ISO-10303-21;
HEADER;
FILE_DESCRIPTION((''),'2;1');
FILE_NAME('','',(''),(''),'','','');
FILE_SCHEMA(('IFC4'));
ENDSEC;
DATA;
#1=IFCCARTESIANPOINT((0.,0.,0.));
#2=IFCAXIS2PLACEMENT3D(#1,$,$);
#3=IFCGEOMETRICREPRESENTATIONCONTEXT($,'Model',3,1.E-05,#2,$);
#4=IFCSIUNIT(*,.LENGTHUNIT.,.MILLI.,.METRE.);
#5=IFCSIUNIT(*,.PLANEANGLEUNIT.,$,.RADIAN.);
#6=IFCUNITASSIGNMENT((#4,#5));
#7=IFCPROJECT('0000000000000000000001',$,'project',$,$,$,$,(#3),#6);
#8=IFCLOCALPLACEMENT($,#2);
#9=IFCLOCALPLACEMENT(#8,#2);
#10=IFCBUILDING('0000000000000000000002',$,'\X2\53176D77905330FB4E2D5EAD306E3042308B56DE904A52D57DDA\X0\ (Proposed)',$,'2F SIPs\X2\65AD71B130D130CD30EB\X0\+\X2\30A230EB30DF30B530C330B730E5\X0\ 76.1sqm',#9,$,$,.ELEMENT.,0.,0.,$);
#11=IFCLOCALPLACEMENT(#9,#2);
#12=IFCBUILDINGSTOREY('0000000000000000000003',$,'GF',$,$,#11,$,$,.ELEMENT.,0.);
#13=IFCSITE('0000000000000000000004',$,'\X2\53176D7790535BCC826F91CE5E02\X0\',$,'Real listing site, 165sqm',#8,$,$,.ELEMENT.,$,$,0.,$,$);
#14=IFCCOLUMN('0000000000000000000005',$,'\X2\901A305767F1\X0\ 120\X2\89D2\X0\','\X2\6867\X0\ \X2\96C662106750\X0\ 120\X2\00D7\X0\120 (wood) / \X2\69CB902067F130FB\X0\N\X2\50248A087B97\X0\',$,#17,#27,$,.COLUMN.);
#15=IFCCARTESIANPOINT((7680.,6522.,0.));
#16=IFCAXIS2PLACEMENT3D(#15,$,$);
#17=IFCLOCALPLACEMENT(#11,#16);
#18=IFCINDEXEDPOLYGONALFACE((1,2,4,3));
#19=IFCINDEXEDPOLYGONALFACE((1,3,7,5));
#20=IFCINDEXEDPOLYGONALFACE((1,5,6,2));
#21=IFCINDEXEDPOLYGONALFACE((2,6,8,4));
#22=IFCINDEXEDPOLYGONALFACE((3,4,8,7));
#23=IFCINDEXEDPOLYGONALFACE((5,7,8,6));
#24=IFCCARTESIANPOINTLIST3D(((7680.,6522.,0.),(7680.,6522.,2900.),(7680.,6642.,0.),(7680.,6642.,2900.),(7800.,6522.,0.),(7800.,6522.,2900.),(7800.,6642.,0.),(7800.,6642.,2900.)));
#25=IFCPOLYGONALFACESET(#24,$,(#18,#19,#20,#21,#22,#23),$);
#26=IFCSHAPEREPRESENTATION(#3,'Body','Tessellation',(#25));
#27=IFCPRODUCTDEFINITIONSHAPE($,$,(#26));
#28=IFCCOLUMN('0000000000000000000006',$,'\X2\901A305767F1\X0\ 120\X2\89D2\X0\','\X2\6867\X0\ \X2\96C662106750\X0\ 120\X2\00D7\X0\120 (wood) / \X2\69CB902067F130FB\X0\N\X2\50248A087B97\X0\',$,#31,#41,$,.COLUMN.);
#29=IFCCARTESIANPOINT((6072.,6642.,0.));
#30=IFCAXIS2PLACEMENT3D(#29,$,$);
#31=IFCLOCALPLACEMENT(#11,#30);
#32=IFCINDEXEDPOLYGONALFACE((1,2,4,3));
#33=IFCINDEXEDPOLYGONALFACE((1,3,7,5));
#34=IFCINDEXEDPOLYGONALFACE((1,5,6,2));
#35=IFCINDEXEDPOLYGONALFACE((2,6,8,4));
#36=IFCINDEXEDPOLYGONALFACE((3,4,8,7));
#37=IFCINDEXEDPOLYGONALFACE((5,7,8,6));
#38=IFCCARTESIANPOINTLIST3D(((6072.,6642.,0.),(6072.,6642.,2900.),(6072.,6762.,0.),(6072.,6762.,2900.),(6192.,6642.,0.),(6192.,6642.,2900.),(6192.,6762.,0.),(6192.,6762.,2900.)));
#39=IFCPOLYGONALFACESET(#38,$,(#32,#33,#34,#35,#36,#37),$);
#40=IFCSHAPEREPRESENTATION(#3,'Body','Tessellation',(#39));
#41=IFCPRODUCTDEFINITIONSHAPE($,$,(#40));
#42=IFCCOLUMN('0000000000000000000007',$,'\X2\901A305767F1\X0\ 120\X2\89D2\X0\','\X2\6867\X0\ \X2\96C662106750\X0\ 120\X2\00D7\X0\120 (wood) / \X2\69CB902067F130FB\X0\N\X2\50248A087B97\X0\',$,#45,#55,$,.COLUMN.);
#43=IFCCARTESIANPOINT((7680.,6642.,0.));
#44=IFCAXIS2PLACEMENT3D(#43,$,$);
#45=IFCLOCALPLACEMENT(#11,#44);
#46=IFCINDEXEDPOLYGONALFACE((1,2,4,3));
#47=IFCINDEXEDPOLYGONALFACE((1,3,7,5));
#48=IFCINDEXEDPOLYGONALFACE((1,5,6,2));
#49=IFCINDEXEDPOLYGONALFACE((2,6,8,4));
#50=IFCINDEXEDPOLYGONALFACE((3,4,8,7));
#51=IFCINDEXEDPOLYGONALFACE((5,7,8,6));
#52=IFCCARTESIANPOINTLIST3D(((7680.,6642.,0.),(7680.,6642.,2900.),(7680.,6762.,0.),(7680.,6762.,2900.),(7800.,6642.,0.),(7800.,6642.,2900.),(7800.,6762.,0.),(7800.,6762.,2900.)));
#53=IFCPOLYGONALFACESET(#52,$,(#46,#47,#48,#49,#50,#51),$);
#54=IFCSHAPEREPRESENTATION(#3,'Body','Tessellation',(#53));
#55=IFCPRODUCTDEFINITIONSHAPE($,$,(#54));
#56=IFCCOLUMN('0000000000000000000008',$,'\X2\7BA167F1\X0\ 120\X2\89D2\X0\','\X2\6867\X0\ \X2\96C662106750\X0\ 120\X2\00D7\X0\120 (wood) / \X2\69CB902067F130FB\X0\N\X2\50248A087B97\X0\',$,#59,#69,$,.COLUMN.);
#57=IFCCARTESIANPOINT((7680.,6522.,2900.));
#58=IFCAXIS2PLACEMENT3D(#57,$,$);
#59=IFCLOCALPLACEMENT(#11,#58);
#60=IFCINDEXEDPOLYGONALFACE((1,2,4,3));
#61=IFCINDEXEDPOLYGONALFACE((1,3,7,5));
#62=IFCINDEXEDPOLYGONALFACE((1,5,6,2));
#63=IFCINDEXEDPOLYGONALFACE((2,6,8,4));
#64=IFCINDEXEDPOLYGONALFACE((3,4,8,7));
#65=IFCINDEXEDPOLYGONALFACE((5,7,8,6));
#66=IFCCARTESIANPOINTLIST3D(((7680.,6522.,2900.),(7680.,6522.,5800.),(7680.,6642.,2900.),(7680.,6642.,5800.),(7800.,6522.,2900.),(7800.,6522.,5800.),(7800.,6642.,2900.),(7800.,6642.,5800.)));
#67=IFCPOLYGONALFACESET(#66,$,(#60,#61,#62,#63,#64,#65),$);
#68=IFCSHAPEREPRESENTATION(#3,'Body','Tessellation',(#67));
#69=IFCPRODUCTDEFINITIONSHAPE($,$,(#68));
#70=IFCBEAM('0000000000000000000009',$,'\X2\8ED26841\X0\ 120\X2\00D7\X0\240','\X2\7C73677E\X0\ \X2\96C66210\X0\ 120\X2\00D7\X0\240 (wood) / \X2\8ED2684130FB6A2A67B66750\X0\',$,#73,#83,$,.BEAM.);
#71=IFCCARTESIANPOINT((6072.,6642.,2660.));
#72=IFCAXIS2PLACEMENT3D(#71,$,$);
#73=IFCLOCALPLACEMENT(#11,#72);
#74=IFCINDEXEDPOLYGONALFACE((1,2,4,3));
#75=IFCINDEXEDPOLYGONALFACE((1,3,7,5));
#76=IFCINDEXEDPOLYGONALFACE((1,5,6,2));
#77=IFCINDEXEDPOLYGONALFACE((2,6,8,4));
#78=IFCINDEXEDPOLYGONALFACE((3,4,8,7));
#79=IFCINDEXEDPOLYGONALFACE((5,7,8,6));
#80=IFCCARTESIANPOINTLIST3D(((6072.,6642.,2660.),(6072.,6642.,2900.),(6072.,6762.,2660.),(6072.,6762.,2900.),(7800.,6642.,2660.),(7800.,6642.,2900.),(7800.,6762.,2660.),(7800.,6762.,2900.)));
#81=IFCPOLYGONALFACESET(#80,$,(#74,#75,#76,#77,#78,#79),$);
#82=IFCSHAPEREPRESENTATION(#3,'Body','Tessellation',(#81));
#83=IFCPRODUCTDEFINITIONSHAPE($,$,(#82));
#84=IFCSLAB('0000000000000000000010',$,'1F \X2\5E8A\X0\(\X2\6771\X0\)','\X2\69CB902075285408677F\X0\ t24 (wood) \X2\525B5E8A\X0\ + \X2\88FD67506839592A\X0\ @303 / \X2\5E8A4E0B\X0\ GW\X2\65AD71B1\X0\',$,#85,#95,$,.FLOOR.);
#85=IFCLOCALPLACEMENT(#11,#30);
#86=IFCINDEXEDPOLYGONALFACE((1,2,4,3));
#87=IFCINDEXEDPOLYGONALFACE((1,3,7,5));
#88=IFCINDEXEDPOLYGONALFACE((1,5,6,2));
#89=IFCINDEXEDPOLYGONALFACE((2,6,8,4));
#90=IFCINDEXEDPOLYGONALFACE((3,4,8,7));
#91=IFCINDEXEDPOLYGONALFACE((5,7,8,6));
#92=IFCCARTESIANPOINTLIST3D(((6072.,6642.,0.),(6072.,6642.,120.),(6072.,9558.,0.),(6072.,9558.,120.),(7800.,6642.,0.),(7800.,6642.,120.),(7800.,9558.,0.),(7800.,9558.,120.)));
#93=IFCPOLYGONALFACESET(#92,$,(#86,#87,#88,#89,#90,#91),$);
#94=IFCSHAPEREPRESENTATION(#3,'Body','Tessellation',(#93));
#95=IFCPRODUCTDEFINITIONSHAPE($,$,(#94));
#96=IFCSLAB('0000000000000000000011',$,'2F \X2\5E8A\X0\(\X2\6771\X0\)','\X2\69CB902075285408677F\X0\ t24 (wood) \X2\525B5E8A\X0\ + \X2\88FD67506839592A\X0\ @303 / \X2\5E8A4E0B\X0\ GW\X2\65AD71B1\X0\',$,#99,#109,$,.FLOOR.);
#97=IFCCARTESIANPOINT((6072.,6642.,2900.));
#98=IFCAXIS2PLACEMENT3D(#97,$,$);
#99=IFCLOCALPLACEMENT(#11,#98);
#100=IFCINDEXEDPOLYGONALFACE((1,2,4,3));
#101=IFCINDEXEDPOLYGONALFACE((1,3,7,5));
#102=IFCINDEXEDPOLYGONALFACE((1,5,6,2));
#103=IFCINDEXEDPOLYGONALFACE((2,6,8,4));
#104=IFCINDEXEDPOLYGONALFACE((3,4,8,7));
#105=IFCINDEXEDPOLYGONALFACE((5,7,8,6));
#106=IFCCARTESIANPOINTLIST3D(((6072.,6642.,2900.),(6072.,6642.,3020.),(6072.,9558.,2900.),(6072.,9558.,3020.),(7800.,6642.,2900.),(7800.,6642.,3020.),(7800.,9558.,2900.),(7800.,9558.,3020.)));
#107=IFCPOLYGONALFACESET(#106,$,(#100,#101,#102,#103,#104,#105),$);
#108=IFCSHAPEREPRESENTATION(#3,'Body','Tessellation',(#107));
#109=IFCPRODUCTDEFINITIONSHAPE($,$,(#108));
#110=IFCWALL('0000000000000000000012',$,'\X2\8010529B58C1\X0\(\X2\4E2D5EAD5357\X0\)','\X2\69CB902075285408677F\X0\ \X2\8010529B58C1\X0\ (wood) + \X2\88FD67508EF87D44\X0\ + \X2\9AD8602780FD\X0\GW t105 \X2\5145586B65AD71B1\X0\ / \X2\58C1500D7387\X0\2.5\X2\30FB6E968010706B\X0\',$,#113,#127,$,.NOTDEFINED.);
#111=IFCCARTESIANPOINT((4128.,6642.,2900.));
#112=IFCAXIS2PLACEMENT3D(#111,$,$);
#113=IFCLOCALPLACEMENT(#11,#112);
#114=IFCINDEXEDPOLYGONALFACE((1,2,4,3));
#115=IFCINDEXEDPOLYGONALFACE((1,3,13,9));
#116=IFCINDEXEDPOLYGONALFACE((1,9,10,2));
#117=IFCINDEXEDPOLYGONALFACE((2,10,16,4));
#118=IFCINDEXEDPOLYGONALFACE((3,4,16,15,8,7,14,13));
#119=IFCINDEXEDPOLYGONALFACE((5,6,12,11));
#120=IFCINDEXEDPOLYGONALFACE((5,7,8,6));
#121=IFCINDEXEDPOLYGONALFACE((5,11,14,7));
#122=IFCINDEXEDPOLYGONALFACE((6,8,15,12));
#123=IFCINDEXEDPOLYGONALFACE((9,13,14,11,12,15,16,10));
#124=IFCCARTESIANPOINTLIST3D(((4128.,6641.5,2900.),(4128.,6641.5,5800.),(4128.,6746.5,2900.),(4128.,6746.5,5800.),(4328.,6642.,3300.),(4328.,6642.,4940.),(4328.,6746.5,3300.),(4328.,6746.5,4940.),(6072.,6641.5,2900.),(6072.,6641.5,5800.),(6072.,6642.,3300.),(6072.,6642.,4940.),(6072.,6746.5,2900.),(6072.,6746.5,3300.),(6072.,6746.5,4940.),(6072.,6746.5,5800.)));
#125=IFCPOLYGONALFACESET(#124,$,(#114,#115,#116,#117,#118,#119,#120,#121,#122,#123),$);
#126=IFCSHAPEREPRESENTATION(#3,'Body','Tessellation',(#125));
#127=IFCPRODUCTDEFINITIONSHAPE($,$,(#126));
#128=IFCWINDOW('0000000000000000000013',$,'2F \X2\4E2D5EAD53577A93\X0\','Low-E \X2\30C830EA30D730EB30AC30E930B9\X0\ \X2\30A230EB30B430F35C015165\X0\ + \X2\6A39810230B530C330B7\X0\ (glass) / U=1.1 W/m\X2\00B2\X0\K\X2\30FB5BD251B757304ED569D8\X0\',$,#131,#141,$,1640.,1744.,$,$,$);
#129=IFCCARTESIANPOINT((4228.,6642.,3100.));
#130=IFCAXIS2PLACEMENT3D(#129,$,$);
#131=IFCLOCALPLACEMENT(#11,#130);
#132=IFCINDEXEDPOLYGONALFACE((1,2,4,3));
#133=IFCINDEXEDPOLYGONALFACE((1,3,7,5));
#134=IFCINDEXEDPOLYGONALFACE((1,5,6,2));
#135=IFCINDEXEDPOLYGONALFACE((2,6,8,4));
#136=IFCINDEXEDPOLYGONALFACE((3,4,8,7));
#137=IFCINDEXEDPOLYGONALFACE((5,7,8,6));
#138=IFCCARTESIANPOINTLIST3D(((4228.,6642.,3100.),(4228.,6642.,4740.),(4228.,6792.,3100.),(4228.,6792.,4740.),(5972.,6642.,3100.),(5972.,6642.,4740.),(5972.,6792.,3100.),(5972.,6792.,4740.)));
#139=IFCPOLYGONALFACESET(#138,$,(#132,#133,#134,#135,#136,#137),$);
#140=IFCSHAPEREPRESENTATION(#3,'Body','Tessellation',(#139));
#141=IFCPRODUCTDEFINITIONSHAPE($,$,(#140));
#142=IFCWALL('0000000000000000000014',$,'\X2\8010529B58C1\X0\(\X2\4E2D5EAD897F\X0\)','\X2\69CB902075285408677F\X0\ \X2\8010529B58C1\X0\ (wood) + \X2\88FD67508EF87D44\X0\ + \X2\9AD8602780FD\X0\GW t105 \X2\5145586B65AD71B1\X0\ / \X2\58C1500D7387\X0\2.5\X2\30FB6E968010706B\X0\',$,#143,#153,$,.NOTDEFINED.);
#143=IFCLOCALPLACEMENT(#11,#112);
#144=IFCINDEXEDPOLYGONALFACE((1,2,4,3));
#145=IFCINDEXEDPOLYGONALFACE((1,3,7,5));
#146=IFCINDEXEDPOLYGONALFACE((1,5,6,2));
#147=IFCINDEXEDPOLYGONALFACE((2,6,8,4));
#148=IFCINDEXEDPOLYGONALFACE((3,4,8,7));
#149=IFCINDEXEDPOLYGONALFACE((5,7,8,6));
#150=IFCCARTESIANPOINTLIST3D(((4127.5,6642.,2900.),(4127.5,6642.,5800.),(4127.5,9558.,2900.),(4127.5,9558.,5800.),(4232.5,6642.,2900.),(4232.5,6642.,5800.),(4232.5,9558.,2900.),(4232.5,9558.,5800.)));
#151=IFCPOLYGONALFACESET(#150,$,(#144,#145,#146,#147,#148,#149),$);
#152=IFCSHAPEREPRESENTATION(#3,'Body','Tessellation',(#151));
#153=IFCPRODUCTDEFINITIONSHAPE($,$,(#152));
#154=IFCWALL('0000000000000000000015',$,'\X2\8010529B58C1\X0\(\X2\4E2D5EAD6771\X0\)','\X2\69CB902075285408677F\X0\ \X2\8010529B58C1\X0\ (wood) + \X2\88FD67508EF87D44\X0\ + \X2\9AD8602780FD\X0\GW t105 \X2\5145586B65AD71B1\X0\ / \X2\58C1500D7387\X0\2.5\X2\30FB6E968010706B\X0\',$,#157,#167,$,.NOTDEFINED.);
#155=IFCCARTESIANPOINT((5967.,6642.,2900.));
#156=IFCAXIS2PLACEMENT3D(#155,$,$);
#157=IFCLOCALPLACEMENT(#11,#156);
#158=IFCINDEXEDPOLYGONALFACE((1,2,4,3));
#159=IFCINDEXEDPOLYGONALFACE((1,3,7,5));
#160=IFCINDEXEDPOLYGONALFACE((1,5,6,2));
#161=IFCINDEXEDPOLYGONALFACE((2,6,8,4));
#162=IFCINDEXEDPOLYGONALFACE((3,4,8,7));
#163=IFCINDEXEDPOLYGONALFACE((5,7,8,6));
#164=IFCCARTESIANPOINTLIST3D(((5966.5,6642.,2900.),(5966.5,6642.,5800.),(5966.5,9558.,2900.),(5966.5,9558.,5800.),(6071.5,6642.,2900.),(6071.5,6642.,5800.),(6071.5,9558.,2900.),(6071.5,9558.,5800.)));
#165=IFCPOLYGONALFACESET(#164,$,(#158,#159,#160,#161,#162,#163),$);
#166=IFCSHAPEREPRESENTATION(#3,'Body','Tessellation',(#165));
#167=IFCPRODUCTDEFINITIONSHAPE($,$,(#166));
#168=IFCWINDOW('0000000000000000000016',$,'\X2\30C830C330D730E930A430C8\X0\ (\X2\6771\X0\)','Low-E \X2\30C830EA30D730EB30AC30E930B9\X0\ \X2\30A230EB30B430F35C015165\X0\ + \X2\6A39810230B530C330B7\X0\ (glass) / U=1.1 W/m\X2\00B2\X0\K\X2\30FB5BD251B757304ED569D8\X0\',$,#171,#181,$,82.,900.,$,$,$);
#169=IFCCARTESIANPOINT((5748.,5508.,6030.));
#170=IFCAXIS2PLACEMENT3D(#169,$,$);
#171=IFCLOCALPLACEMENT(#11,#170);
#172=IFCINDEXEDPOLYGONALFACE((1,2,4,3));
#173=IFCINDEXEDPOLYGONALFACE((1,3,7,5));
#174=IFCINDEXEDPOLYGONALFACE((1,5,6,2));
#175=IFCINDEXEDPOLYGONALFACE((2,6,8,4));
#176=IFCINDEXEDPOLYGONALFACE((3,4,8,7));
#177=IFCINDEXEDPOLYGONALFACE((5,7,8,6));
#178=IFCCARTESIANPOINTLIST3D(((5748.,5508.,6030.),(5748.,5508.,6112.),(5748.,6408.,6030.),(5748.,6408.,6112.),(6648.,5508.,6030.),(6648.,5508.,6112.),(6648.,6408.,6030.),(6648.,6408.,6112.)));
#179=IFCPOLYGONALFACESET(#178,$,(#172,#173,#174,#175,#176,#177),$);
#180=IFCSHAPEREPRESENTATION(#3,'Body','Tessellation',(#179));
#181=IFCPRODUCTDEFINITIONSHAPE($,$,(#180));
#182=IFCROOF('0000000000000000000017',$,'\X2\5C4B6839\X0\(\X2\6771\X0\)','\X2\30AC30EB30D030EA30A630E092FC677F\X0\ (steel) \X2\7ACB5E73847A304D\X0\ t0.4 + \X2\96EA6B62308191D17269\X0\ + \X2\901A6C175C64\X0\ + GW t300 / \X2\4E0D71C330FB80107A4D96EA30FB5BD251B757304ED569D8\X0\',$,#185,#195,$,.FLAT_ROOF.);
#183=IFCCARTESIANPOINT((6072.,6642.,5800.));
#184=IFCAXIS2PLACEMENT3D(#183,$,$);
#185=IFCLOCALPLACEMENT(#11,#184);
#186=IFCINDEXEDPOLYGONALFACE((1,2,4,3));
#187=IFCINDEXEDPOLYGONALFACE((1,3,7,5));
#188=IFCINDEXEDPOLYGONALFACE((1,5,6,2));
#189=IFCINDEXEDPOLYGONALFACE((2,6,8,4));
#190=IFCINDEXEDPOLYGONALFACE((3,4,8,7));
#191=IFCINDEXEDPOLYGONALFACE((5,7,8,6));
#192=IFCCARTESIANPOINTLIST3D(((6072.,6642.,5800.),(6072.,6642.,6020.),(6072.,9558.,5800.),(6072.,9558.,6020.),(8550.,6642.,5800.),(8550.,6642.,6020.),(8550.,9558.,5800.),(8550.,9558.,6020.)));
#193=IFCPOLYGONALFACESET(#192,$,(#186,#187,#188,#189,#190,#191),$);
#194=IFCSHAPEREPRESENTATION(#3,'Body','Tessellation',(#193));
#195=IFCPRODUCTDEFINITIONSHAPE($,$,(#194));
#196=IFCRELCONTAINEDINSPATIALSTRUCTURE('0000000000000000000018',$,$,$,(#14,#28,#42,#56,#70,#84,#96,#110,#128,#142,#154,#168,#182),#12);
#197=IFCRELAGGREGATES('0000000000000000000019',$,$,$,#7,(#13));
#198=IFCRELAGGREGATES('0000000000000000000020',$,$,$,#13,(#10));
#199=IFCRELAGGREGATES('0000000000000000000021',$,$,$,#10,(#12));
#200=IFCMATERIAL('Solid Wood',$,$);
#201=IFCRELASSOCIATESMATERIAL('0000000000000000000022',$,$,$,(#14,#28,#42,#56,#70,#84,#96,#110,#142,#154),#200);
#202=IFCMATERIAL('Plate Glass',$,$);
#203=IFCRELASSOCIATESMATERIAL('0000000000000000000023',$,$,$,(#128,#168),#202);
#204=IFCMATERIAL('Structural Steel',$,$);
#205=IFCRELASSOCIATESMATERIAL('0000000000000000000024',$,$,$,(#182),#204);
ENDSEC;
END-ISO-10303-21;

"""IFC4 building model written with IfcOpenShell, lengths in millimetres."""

from ifc_helpers import new_model, si_unit, frame, frame_2d, origin, place, context, project, spatial, rectangle, extrude, material, element, fill, save


model = new_model("IFC4")

# Units and contexts
model_context = context("Model", 3, precision=1e-05, world=origin())
ifc_project = project(units=[si_unit("LENGTHUNIT", "METRE", prefix="MILLI"), si_unit("PLANEANGLEUNIT", "RADIAN")], contexts=[model_context])

# Site, building, storey
site_placement = place(None, origin())
site = spatial("IfcSite", under=ifc_project, at=site_placement, Name="北海道富良野市", ObjectType="Real listing site, 165sqm", CompositionType="ELEMENT", RefElevation=0.0)
building_placement = place(site_placement, origin())
building = spatial("IfcBuilding", under=site, at=building_placement, Name="北海道・中庭のある回遊動線 (Proposed)", ObjectType="2F SIPs断熱パネル+アルミサッシュ 76.1sqm", CompositionType="ELEMENT", ElevationOfRefHeight=0.0, ElevationOfTerrain=0.0)
storey_placement = place(building_placement, origin())
storey = spatial("IfcBuildingStorey", under=building, at=storey_placement, Name="GF", CompositionType="ELEMENT", Elevation=0.0)

# Columns
ifc_material_1 = material(Name="Solid Wood")
column_1_placement = place(storey_placement, frame((7680.0, 6522.0, 0.0)))
element("IfcColumn", 1, at=column_1_placement, inside=storey, material=ifc_material_1, Name="通し柱 120角", Description="桧 集成材 120×120 (wood) / 構造柱・N値計算", PredefinedType="COLUMN", context=model_context, shape_type="SweptSolid", body=[
    extrude(rectangle(XDim=120.0, YDim=120.0, at=frame_2d((60.0, 60.0))), frame((7680.0, 6522.0, 0.0)), (0.0, 0.0, 1.0), 2900.0),
])
column_2_placement = place(storey_placement, frame((6072.0, 6642.0, 0.0)))
element("IfcColumn", 2, at=column_2_placement, inside=storey, material=ifc_material_1, Name="通し柱 120角", Description="桧 集成材 120×120 (wood) / 構造柱・N値計算", PredefinedType="COLUMN", context=model_context, shape_type="SweptSolid", body=[
    extrude(rectangle(XDim=120.0, YDim=120.0, at=frame_2d((60.0, 60.0))), frame((6072.0, 6642.0, 0.0)), (0.0, 0.0, 1.0), 2900.0),
])
column_3_placement = place(storey_placement, frame((7680.0, 6642.0, 0.0)))
element("IfcColumn", 3, at=column_3_placement, inside=storey, material=ifc_material_1, Name="通し柱 120角", Description="桧 集成材 120×120 (wood) / 構造柱・N値計算", PredefinedType="COLUMN", context=model_context, shape_type="SweptSolid", body=[
    extrude(rectangle(XDim=120.0, YDim=120.0, at=frame_2d((60.0, 60.0))), frame((7680.0, 6642.0, 0.0)), (0.0, 0.0, 1.0), 2900.0),
])
column_4_placement = place(storey_placement, frame((7680.0, 6522.0, 2900.0)))
element("IfcColumn", 4, at=column_4_placement, inside=storey, material=ifc_material_1, Name="管柱 120角", Description="桧 集成材 120×120 (wood) / 構造柱・N値計算", PredefinedType="COLUMN", context=model_context, shape_type="SweptSolid", body=[
    extrude(rectangle(XDim=120.0, YDim=120.0, at=frame_2d((60.0, 60.0))), frame((7680.0, 6522.0, 2900.0)), (0.0, 0.0, 1.0), 2900.0),
])

# Beam
beam_1_placement = place(storey_placement, frame((6072.0, 6642.0, 2660.0)))
element("IfcBeam", 5, at=beam_1_placement, inside=storey, material=ifc_material_1, Name="軒桁 120×240", Description="米松 集成 120×240 (wood) / 軒桁・横架材", PredefinedType="BEAM", context=model_context, shape_type="SweptSolid", body=[
    extrude(rectangle(XDim=1728.0, YDim=120.0, at=frame_2d((864.0, 60.0))), frame((6072.0, 6642.0, 2660.0)), (0.0, 0.0, 1.0), 240.0),
])

# Slabs
slab_1_placement = place(storey_placement, frame((6072.0, 6642.0, 0.0)))
element("IfcSlab", 6, at=slab_1_placement, inside=storey, material=ifc_material_1, Name="1F 床(東)", Description="構造用合板 t24 (wood) 剛床 + 製材根太 @303 / 床下 GW断熱", PredefinedType="FLOOR", context=model_context, shape_type="SweptSolid", body=[
    extrude(rectangle(XDim=1728.0, YDim=2916.0, at=frame_2d((864.0, 1458.0))), frame((6072.0, 6642.0, 0.0)), (0.0, 0.0, 1.0), 120.0),
])
slab_2_placement = place(storey_placement, frame((6072.0, 6642.0, 2900.0)))
element("IfcSlab", 7, at=slab_2_placement, inside=storey, material=ifc_material_1, Name="2F 床(東)", Description="構造用合板 t24 (wood) 剛床 + 製材根太 @303 / 床下 GW断熱", PredefinedType="FLOOR", context=model_context, shape_type="SweptSolid", body=[
    extrude(rectangle(XDim=1728.0, YDim=2916.0, at=frame_2d((864.0, 1458.0))), frame((6072.0, 6642.0, 2900.0)), (0.0, 0.0, 1.0), 120.0),
])

# Wall, opening, window
wall_1_placement = place(storey_placement, frame((4128.0, 6642.0, 2900.0)))
wall_1 = element("IfcWall", 8, at=wall_1_placement, inside=storey, material=ifc_material_1, Name="耐力壁(中庭南)", Description="構造用合板 耐力壁 (wood) + 製材軸組 + 高性能GW t105 充填断熱 / 壁倍率2.5・準耐火", PredefinedType="NOTDEFINED", context=model_context, shape_type="SweptSolid", body=[
    extrude(rectangle(XDim=1944.0, YDim=105.0, at=frame_2d((972.0, 52.0))), frame((4128.0, 6642.0, 2900.0)), (0.0, 0.0, 1.0), 2900.0),
])
opening_placement = place(storey_placement, frame((4228.0, 6642.0, 3100.0)))
opening = element("IfcOpeningElement", 9, at=opening_placement, cuts=wall_1, PredefinedType="NOTDEFINED", context=model_context, shape_type="SweptSolid", body=[
    extrude(rectangle(XDim=1744.0, YDim=150.0, at=frame_2d((872.0, 75.0))), frame((4228.0, 6642.0, 3100.0)), (0.0, 0.0, 1.0), 1640.0),
])
ifc_material_2 = material(Name="Plate Glass")
window_1_placement = place(storey_placement, frame((4228.0, 6642.0, 3100.0)))
window_1 = element("IfcWindow", 10, at=window_1_placement, inside=storey, material=ifc_material_2, Name="2F 中庭南窓", Description="Low-E トリプルガラス アルゴン封入 + 樹脂サッシ (glass) / U=1.1 W/m²K・寒冷地仕様", OverallHeight=1640.0, OverallWidth=1744.0, context=model_context, shape_type="SweptSolid", body=[
    extrude(rectangle(XDim=1744.0, YDim=150.0, at=frame_2d((872.0, 75.0))), frame((4228.0, 6642.0, 3100.0)), (0.0, 0.0, 1.0), 1640.0),
])
fill(opening, window_1)

# Walls
wall_2_placement = place(storey_placement, frame((4128.0, 6642.0, 2900.0)))
element("IfcWall", 11, at=wall_2_placement, inside=storey, material=ifc_material_1, Name="耐力壁(中庭西)", Description="構造用合板 耐力壁 (wood) + 製材軸組 + 高性能GW t105 充填断熱 / 壁倍率2.5・準耐火", PredefinedType="NOTDEFINED", context=model_context, shape_type="SweptSolid", body=[
    extrude(rectangle(XDim=105.0, YDim=2916.0, at=frame_2d((52.0, 1458.0))), frame((4128.0, 6642.0, 2900.0)), (0.0, 0.0, 1.0), 2900.0),
])
wall_3_placement = place(storey_placement, frame((5967.0, 6642.0, 2900.0)))
element("IfcWall", 12, at=wall_3_placement, inside=storey, material=ifc_material_1, Name="耐力壁(中庭東)", Description="構造用合板 耐力壁 (wood) + 製材軸組 + 高性能GW t105 充填断熱 / 壁倍率2.5・準耐火", PredefinedType="NOTDEFINED", context=model_context, shape_type="SweptSolid", body=[
    extrude(rectangle(XDim=105.0, YDim=2916.0, at=frame_2d((52.0, 1458.0))), frame((5967.0, 6642.0, 2900.0)), (0.0, 0.0, 1.0), 2900.0),
])

# Window
window_2_placement = place(storey_placement, frame((5748.0, 5508.0, 6030.0)))
element("IfcWindow", 13, at=window_2_placement, inside=storey, material=ifc_material_2, Name="トップライト (東)", Description="Low-E トリプルガラス アルゴン封入 + 樹脂サッシ (glass) / U=1.1 W/m²K・寒冷地仕様", OverallHeight=82.0, OverallWidth=900.0, context=model_context, shape_type="SweptSolid", body=[
    extrude(rectangle(XDim=900.0, YDim=900.0, at=frame_2d((450.0, 450.0))), frame((5748.0, 5508.0, 6030.0)), (0.0, 0.0, 1.0), 82.0),
])

# Roof
ifc_material_3 = material(Name="Structural Steel")
for number, where, name in (
    (14, (6072.0, 6642.0, 5800.0), "屋根(東)"),
):
    element("IfcRoof", number, at=place(storey_placement, frame(where)), inside=storey, material=ifc_material_3, Name=name, Description="ガルバリウム鋼板 (steel) 立平葺き t0.4 + 雪止め金物 + 通気層 + GW t300 / 不燃・耐積雪・寒冷地仕様", PredefinedType="FLAT_ROOF", context=model_context, shape_type="SweptSolid", body=[
        extrude(rectangle(XDim=2478.0, YDim=2916.0, at=frame_2d((1239.0, 1458.0))), frame((6072.0, 6642.0, 5800.0)), (0.0, 0.0, 1.0), 220.0),
    ])

save(model, "model.ifc")
